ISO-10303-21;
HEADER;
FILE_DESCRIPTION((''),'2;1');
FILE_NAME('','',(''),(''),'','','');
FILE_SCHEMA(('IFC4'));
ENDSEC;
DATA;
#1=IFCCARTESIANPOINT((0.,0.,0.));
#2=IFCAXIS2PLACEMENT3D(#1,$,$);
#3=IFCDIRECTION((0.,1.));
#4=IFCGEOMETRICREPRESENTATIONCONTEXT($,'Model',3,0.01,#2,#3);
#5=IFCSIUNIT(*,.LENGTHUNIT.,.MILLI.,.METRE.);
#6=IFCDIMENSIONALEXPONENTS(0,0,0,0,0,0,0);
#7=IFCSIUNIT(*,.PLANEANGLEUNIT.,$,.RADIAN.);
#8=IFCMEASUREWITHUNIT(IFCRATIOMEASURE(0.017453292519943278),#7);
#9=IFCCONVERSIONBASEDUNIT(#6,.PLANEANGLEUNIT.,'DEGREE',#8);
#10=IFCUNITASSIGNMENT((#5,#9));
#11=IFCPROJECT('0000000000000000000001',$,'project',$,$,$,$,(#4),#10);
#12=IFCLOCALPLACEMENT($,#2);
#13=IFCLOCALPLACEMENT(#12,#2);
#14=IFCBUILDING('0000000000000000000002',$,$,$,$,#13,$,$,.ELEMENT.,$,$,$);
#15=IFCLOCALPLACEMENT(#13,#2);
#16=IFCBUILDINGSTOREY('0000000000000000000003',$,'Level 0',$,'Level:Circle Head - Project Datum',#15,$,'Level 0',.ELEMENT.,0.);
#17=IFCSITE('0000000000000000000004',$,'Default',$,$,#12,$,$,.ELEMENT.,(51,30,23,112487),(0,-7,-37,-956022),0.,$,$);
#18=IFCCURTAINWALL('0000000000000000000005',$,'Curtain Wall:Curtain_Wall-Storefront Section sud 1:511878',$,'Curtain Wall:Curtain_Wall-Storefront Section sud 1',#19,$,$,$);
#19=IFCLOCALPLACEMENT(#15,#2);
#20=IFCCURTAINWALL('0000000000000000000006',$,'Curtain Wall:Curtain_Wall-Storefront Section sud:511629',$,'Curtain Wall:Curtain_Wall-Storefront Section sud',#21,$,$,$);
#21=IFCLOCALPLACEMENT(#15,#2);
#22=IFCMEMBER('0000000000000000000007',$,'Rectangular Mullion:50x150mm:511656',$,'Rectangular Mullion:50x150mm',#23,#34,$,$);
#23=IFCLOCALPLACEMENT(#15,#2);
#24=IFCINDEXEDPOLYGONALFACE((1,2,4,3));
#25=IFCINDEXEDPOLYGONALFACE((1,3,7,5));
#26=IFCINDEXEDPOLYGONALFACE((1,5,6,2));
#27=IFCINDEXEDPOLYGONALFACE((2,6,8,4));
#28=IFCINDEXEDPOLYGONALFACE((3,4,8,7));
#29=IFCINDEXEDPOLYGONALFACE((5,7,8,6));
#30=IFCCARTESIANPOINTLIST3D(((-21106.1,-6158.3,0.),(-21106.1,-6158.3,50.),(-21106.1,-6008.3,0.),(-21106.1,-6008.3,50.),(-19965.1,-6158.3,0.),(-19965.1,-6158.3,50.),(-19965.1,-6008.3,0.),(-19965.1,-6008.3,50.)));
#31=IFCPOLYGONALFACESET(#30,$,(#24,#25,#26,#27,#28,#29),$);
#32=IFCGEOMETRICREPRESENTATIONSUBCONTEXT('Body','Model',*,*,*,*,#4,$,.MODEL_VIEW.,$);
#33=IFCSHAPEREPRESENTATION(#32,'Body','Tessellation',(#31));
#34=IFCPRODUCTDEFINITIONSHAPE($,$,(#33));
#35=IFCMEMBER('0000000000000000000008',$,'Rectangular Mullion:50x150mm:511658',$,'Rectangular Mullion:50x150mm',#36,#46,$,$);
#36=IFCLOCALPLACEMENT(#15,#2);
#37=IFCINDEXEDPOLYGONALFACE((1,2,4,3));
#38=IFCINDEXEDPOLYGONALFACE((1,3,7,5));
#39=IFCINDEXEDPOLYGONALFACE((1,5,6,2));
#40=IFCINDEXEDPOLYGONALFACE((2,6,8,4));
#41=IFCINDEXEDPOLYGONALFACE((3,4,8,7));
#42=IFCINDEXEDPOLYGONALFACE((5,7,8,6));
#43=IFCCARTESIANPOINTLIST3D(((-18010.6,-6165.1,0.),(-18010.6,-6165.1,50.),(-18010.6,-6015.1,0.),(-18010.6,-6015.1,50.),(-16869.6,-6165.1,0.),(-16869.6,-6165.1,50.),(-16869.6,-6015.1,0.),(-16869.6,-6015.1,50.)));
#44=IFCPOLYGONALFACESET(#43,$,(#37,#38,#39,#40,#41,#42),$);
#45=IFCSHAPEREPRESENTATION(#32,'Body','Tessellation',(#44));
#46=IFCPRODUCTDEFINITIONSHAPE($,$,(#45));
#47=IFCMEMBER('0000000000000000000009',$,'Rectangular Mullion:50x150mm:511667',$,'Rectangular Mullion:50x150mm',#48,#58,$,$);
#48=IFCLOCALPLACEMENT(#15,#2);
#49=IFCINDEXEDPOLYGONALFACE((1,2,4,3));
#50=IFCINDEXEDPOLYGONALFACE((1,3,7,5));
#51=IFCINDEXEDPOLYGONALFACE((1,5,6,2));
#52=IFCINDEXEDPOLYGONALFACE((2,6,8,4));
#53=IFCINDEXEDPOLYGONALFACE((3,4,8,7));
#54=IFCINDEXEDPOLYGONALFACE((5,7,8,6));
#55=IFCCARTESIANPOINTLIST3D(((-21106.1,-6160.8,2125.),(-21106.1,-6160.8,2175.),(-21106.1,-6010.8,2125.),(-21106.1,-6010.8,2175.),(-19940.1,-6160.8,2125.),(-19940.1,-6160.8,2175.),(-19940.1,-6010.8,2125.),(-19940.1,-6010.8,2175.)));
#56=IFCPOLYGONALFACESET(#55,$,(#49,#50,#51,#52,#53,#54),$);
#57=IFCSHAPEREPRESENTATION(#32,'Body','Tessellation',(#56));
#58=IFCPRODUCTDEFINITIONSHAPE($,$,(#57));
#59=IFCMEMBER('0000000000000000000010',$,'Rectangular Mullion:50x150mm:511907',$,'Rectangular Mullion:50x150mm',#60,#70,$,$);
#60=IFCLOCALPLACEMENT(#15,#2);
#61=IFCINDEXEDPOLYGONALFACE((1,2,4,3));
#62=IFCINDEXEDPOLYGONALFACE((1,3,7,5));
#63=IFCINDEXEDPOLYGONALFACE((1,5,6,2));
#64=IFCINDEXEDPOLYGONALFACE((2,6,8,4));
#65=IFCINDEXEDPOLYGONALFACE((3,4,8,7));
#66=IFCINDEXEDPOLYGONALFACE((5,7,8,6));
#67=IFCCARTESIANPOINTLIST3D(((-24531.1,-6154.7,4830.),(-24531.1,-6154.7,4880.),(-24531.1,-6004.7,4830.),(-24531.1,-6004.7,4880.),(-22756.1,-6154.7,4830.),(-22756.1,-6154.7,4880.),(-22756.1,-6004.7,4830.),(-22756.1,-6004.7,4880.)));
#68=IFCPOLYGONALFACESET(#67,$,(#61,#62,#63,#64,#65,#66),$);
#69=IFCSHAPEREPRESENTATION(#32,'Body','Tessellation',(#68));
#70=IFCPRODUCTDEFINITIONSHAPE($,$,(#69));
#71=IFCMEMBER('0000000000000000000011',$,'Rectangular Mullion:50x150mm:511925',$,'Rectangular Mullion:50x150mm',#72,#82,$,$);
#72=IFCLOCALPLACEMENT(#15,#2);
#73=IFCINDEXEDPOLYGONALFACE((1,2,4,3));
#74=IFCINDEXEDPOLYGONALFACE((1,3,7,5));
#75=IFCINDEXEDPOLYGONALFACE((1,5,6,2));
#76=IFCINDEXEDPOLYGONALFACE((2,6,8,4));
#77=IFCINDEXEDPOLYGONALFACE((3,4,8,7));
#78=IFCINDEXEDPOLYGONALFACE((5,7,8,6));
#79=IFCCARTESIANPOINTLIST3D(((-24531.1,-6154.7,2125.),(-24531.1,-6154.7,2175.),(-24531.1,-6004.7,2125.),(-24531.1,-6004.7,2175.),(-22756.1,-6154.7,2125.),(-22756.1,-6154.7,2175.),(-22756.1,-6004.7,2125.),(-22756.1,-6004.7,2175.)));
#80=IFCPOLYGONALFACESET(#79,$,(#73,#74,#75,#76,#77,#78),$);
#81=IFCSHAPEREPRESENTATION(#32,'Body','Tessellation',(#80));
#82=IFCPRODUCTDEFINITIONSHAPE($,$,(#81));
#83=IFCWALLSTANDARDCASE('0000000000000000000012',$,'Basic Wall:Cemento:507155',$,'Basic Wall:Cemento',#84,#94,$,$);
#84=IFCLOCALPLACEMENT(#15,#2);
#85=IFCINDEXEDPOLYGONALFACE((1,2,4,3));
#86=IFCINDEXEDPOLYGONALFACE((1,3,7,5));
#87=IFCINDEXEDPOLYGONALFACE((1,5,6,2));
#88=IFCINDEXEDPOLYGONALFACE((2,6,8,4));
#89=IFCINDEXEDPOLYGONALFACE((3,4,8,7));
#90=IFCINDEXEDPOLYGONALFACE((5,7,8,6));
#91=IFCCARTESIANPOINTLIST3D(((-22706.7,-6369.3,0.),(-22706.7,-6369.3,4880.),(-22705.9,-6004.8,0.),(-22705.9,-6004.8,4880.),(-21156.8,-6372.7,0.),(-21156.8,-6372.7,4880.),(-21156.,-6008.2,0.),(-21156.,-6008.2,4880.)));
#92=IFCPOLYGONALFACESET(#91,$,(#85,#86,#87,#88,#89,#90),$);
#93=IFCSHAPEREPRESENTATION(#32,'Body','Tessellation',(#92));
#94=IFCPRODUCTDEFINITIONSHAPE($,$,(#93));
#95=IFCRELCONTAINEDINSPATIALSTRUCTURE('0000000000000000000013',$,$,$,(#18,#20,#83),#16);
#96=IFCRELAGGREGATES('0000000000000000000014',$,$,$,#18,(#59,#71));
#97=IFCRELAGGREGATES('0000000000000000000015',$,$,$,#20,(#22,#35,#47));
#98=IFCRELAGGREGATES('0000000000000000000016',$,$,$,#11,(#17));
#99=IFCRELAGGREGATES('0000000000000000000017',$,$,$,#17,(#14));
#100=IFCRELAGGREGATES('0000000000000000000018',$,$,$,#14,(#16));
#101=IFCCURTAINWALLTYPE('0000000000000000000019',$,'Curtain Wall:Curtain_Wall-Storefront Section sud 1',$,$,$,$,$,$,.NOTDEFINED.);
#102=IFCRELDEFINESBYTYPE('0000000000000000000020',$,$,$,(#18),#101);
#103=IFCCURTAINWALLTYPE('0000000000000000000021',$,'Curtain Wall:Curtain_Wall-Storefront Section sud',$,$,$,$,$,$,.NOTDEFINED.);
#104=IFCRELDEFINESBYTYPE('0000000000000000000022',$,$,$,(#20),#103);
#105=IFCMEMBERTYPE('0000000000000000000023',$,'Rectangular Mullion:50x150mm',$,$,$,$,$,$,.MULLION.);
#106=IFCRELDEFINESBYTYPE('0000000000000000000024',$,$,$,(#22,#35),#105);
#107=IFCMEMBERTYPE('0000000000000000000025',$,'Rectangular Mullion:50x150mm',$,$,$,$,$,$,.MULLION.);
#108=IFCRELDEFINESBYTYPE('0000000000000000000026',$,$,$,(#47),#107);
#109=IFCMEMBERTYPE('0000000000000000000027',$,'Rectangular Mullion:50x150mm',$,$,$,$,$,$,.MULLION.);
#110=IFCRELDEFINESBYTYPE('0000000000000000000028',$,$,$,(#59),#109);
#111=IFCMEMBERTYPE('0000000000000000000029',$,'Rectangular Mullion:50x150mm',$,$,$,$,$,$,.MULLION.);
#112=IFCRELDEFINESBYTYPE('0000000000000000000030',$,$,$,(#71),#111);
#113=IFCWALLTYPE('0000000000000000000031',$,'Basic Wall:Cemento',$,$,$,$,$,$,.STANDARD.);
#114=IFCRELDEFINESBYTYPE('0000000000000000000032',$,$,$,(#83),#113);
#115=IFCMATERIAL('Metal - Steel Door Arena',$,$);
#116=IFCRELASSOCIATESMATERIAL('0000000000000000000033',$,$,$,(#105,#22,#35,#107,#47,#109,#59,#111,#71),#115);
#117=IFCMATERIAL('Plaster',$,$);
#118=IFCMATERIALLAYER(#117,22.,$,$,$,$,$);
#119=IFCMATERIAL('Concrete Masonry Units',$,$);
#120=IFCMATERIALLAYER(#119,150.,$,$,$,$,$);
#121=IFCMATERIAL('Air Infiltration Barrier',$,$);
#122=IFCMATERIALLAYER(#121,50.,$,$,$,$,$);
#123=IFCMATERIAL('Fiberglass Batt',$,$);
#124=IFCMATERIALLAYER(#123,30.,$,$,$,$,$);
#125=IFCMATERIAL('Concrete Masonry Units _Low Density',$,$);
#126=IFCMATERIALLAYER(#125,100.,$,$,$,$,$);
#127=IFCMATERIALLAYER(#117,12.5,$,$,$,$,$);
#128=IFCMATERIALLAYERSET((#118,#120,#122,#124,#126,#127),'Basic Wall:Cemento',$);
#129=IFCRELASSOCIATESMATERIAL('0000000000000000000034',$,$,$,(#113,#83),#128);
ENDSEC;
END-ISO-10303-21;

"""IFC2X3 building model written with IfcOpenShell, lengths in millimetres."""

from ifc_helpers import new_model, entity, si_unit, converted_unit, direction, frame, frame_2d, origin, origin_2d_with_axis, place, context, subcontext, project, spatial, rectangle, extrude, source, transform, mapped, material, layer, layer_set, layer_usage, type_object, type_shapes, element, aggregate, save


model = new_model("IFC2X3")

# Units and contexts
model_context = context("Model", 3, precision=0.01, world=origin(), true_north=direction((0.0, 1.0)))
body_context = subcontext(model_context, "Body", "Model", "MODEL_VIEW")
ifc_project = project(units=[si_unit("LENGTHUNIT", "METRE", prefix="MILLI"), converted_unit("PLANEANGLEUNIT", "DEGREE", entity("IfcRatioMeasure", 0.017453292519943278), si_unit("PLANEANGLEUNIT", "RADIAN"), dimensions=[0, 0, 0, 0, 0, 0, 0])], contexts=[model_context])

# Site, building, storey
site_placement = place(None, origin())
site = spatial("IfcSite", under=ifc_project, at=site_placement, Name="Default", CompositionType="ELEMENT", RefLatitude=(51, 30, 23, 112487), RefLongitude=(0, -7, -37, -956022), RefElevation=0.0)
building_placement = place(site_placement, origin())
building = spatial("IfcBuilding", under=site, at=building_placement, CompositionType="ELEMENT")
storey_placement = place(building_placement, origin())
storey = spatial("IfcBuildingStorey", under=building, at=storey_placement, Name="Level 0", ObjectType="Level:Circle Head - Project Datum", LongName="Level 0", CompositionType="ELEMENT", Elevation=0.0)

# Curtain wall
curtain_wall_type_1 = type_object("IfcCurtainWallType", Name="Curtain Wall:Curtain_Wall-Storefront Section sud 1", PredefinedType="NOTDEFINED")
curtain_wall_1_placement = place(storey_placement, origin())
curtain_wall_1 = element("IfcCurtainWall", 1, at=curtain_wall_1_placement, inside=storey, type_object=curtain_wall_type_1, Name="Curtain Wall:Curtain_Wall-Storefront Section sud 1:511878", ObjectType="Curtain Wall:Curtain_Wall-Storefront Section sud 1")
ifc_material_1 = material(Name="Metal - Steel Door Arena")

# Curtain wall
curtain_wall_type_2 = type_object("IfcCurtainWallType", Name="Curtain Wall:Curtain_Wall-Storefront Section sud", PredefinedType="NOTDEFINED")
curtain_wall_2_placement = place(storey_placement, origin())
curtain_wall_2 = element("IfcCurtainWall", 2, at=curtain_wall_2_placement, inside=storey, type_object=curtain_wall_type_2, Name="Curtain Wall:Curtain_Wall-Storefront Section sud:511629", ObjectType="Curtain Wall:Curtain_Wall-Storefront Section sud")

# Members
member_type_1 = type_object("IfcMemberType", Name="Rectangular Mullion:50x150mm", PredefinedType="MULLION", material=ifc_material_1)
shared_shape_1 = source(origin(), body_context, "Body", "SweptSolid", [
    extrude(rectangle(XDim=150.0, YDim=50.0, at=origin_2d_with_axis()), frame((-25.0, 0.0, -1141.0), z_axis=(0.0, 0.0, 1.0), x_axis=(0.0, -1.0, 0.0)), (0.0, 0.0, 1.0), 1141.0),
])
type_shapes(member_type_1, [shared_shape_1])
member_1_placement = place(curtain_wall_2_placement, frame((-21106.1, -6083.3, 0.0), z_axis=(-1.0, 0.0, 0.0), x_axis=(0.0, 0.0, -1.0)))
member_1 = element("IfcMember", 3, at=member_1_placement, type_object=member_type_1, material=ifc_material_1, Name="Rectangular Mullion:50x150mm:511656", ObjectType="Rectangular Mullion:50x150mm", context=body_context, shape_type="MappedRepresentation", body=[
    mapped(shared_shape_1, transform((0.0, 0.0, 0.0), scale=1.0)),
])
member_2_placement = place(curtain_wall_2_placement, frame((-18010.6, -6090.1, 0.0), z_axis=(-1.0, 0.0, 0.0), x_axis=(0.0, 0.0, -1.0)))
member_2 = element("IfcMember", 4, at=member_2_placement, type_object=member_type_1, material=ifc_material_1, Name="Rectangular Mullion:50x150mm:511658", ObjectType="Rectangular Mullion:50x150mm", context=body_context, shape_type="MappedRepresentation", body=[
    mapped(shared_shape_1, transform((0.0, 0.0, 0.0), scale=1.0)),
])
member_type_2 = type_object("IfcMemberType", Name="Rectangular Mullion:50x150mm", PredefinedType="MULLION", material=ifc_material_1)
shared_shape_2 = source(origin(), body_context, "Body", "SweptSolid", [
    extrude(rectangle(XDim=150.0, YDim=50.0, at=origin_2d_with_axis()), frame((0.0, 0.0, -1166.0), z_axis=(0.0, 0.0, 1.0), x_axis=(0.0, -1.0, 0.0)), (0.0, 0.0, 1.0), 1166.0),
])
type_shapes(member_type_2, [shared_shape_2])
member_3_placement = place(curtain_wall_2_placement, frame((-19940.1, -6085.8, 2150.0), z_axis=(1.0, 0.0, 0.0), x_axis=(0.0, 0.0, 1.0)))
member_3 = element("IfcMember", 5, at=member_3_placement, type_object=member_type_2, material=ifc_material_1, Name="Rectangular Mullion:50x150mm:511667", ObjectType="Rectangular Mullion:50x150mm", context=body_context, shape_type="MappedRepresentation", body=[
    mapped(shared_shape_2, transform((0.0, 0.0, 0.0), scale=1.0)),
])
member_type_3 = type_object("IfcMemberType", Name="Rectangular Mullion:50x150mm", PredefinedType="MULLION", material=ifc_material_1)
shared_shape_3 = source(origin(), body_context, "Body", "SweptSolid", [
    extrude(rectangle(XDim=150.0, YDim=50.0, at=origin_2d_with_axis()), frame((-25.0, 0.0, -1775.0), z_axis=(0.0, 0.0, 1.0), x_axis=(0.0, -1.0, 0.0)), (0.0, 0.0, 1.0), 1775.0),
])
type_shapes(member_type_3, [shared_shape_3])
member_4_placement = place(curtain_wall_1_placement, frame((-22756.1, -6079.7, 4880.0), z_axis=(1.0, 0.0, 0.0), x_axis=(0.0, 0.0, 1.0)))
member_4 = element("IfcMember", 6, at=member_4_placement, type_object=member_type_3, material=ifc_material_1, Name="Rectangular Mullion:50x150mm:511907", ObjectType="Rectangular Mullion:50x150mm", context=body_context, shape_type="MappedRepresentation", body=[
    mapped(shared_shape_3, transform((0.0, 0.0, 0.0), scale=1.0)),
])
member_type_4 = type_object("IfcMemberType", Name="Rectangular Mullion:50x150mm", PredefinedType="MULLION", material=ifc_material_1)
shared_shape_4 = source(origin(), body_context, "Body", "SweptSolid", [
    extrude(rectangle(XDim=150.0, YDim=50.0, at=origin_2d_with_axis()), frame((0.0, 0.0, -1775.0), z_axis=(0.0, 0.0, 1.0), x_axis=(0.0, -1.0, 0.0)), (0.0, 0.0, 1.0), 1775.0),
])
type_shapes(member_type_4, [shared_shape_4])
member_5_placement = place(curtain_wall_1_placement, frame((-22756.1, -6079.7, 2150.0), z_axis=(1.0, 0.0, 0.0), x_axis=(0.0, 0.0, 1.0)))
member_5 = element("IfcMember", 7, at=member_5_placement, type_object=member_type_4, material=ifc_material_1, Name="Rectangular Mullion:50x150mm:511925", ObjectType="Rectangular Mullion:50x150mm", context=body_context, shape_type="MappedRepresentation", body=[
    mapped(shared_shape_4, transform((0.0, 0.0, 0.0), scale=1.0)),
])
aggregate(curtain_wall_1, [member_4, member_5])

aggregate(curtain_wall_2, [member_1, member_2, member_3])

# Wall
ifc_material_2 = material(Name="Plaster")
ifc_layer_1 = layer(ifc_material_2, 22.0)
ifc_material_3 = material(Name="Concrete Masonry Units")
ifc_layer_2 = layer(ifc_material_3, 150.0)
ifc_material_4 = material(Name="Air Infiltration Barrier")
ifc_layer_3 = layer(ifc_material_4, 50.0)
ifc_material_5 = material(Name="Fiberglass Batt")
ifc_layer_4 = layer(ifc_material_5, 30.0)
ifc_material_6 = material(Name="Concrete Masonry Units _Low Density")
ifc_layer_5 = layer(ifc_material_6, 100.0)
ifc_layer_6 = layer(ifc_material_2, 12.5)
ifc_layer_set = layer_set([ifc_layer_1, ifc_layer_2, ifc_layer_3, ifc_layer_4, ifc_layer_5, ifc_layer_6], Name="Basic Wall:Cemento")
ifc_layer_usage = layer_usage(ifc_layer_set, "AXIS2", "NEGATIVE", 182.3)
wall_type = type_object("IfcWallType", Name="Basic Wall:Cemento", PredefinedType="STANDARD", material=ifc_layer_set)
wall_placement = place(storey_placement, frame((-21156.4, -6190.4, 0.0), z_axis=(0.0, 0.0, 1.0), x_axis=(-0.999998, 0.002199, 0.0)))
element("IfcWallStandardCase", 8, at=wall_placement, inside=storey, type_object=wall_type, material=ifc_layer_usage, Name="Basic Wall:Cemento:507155", ObjectType="Basic Wall:Cemento", context=body_context, shape_type="SweptSolid", body=[
    extrude(rectangle(XDim=1550.0, YDim=364.5, at=frame_2d((775.0, 0.0), x_axis=(-1.0, 0.0))), origin(), (0.0, 0.0, 1.0), 4880.0),
])

save(model, "model.ifc")
